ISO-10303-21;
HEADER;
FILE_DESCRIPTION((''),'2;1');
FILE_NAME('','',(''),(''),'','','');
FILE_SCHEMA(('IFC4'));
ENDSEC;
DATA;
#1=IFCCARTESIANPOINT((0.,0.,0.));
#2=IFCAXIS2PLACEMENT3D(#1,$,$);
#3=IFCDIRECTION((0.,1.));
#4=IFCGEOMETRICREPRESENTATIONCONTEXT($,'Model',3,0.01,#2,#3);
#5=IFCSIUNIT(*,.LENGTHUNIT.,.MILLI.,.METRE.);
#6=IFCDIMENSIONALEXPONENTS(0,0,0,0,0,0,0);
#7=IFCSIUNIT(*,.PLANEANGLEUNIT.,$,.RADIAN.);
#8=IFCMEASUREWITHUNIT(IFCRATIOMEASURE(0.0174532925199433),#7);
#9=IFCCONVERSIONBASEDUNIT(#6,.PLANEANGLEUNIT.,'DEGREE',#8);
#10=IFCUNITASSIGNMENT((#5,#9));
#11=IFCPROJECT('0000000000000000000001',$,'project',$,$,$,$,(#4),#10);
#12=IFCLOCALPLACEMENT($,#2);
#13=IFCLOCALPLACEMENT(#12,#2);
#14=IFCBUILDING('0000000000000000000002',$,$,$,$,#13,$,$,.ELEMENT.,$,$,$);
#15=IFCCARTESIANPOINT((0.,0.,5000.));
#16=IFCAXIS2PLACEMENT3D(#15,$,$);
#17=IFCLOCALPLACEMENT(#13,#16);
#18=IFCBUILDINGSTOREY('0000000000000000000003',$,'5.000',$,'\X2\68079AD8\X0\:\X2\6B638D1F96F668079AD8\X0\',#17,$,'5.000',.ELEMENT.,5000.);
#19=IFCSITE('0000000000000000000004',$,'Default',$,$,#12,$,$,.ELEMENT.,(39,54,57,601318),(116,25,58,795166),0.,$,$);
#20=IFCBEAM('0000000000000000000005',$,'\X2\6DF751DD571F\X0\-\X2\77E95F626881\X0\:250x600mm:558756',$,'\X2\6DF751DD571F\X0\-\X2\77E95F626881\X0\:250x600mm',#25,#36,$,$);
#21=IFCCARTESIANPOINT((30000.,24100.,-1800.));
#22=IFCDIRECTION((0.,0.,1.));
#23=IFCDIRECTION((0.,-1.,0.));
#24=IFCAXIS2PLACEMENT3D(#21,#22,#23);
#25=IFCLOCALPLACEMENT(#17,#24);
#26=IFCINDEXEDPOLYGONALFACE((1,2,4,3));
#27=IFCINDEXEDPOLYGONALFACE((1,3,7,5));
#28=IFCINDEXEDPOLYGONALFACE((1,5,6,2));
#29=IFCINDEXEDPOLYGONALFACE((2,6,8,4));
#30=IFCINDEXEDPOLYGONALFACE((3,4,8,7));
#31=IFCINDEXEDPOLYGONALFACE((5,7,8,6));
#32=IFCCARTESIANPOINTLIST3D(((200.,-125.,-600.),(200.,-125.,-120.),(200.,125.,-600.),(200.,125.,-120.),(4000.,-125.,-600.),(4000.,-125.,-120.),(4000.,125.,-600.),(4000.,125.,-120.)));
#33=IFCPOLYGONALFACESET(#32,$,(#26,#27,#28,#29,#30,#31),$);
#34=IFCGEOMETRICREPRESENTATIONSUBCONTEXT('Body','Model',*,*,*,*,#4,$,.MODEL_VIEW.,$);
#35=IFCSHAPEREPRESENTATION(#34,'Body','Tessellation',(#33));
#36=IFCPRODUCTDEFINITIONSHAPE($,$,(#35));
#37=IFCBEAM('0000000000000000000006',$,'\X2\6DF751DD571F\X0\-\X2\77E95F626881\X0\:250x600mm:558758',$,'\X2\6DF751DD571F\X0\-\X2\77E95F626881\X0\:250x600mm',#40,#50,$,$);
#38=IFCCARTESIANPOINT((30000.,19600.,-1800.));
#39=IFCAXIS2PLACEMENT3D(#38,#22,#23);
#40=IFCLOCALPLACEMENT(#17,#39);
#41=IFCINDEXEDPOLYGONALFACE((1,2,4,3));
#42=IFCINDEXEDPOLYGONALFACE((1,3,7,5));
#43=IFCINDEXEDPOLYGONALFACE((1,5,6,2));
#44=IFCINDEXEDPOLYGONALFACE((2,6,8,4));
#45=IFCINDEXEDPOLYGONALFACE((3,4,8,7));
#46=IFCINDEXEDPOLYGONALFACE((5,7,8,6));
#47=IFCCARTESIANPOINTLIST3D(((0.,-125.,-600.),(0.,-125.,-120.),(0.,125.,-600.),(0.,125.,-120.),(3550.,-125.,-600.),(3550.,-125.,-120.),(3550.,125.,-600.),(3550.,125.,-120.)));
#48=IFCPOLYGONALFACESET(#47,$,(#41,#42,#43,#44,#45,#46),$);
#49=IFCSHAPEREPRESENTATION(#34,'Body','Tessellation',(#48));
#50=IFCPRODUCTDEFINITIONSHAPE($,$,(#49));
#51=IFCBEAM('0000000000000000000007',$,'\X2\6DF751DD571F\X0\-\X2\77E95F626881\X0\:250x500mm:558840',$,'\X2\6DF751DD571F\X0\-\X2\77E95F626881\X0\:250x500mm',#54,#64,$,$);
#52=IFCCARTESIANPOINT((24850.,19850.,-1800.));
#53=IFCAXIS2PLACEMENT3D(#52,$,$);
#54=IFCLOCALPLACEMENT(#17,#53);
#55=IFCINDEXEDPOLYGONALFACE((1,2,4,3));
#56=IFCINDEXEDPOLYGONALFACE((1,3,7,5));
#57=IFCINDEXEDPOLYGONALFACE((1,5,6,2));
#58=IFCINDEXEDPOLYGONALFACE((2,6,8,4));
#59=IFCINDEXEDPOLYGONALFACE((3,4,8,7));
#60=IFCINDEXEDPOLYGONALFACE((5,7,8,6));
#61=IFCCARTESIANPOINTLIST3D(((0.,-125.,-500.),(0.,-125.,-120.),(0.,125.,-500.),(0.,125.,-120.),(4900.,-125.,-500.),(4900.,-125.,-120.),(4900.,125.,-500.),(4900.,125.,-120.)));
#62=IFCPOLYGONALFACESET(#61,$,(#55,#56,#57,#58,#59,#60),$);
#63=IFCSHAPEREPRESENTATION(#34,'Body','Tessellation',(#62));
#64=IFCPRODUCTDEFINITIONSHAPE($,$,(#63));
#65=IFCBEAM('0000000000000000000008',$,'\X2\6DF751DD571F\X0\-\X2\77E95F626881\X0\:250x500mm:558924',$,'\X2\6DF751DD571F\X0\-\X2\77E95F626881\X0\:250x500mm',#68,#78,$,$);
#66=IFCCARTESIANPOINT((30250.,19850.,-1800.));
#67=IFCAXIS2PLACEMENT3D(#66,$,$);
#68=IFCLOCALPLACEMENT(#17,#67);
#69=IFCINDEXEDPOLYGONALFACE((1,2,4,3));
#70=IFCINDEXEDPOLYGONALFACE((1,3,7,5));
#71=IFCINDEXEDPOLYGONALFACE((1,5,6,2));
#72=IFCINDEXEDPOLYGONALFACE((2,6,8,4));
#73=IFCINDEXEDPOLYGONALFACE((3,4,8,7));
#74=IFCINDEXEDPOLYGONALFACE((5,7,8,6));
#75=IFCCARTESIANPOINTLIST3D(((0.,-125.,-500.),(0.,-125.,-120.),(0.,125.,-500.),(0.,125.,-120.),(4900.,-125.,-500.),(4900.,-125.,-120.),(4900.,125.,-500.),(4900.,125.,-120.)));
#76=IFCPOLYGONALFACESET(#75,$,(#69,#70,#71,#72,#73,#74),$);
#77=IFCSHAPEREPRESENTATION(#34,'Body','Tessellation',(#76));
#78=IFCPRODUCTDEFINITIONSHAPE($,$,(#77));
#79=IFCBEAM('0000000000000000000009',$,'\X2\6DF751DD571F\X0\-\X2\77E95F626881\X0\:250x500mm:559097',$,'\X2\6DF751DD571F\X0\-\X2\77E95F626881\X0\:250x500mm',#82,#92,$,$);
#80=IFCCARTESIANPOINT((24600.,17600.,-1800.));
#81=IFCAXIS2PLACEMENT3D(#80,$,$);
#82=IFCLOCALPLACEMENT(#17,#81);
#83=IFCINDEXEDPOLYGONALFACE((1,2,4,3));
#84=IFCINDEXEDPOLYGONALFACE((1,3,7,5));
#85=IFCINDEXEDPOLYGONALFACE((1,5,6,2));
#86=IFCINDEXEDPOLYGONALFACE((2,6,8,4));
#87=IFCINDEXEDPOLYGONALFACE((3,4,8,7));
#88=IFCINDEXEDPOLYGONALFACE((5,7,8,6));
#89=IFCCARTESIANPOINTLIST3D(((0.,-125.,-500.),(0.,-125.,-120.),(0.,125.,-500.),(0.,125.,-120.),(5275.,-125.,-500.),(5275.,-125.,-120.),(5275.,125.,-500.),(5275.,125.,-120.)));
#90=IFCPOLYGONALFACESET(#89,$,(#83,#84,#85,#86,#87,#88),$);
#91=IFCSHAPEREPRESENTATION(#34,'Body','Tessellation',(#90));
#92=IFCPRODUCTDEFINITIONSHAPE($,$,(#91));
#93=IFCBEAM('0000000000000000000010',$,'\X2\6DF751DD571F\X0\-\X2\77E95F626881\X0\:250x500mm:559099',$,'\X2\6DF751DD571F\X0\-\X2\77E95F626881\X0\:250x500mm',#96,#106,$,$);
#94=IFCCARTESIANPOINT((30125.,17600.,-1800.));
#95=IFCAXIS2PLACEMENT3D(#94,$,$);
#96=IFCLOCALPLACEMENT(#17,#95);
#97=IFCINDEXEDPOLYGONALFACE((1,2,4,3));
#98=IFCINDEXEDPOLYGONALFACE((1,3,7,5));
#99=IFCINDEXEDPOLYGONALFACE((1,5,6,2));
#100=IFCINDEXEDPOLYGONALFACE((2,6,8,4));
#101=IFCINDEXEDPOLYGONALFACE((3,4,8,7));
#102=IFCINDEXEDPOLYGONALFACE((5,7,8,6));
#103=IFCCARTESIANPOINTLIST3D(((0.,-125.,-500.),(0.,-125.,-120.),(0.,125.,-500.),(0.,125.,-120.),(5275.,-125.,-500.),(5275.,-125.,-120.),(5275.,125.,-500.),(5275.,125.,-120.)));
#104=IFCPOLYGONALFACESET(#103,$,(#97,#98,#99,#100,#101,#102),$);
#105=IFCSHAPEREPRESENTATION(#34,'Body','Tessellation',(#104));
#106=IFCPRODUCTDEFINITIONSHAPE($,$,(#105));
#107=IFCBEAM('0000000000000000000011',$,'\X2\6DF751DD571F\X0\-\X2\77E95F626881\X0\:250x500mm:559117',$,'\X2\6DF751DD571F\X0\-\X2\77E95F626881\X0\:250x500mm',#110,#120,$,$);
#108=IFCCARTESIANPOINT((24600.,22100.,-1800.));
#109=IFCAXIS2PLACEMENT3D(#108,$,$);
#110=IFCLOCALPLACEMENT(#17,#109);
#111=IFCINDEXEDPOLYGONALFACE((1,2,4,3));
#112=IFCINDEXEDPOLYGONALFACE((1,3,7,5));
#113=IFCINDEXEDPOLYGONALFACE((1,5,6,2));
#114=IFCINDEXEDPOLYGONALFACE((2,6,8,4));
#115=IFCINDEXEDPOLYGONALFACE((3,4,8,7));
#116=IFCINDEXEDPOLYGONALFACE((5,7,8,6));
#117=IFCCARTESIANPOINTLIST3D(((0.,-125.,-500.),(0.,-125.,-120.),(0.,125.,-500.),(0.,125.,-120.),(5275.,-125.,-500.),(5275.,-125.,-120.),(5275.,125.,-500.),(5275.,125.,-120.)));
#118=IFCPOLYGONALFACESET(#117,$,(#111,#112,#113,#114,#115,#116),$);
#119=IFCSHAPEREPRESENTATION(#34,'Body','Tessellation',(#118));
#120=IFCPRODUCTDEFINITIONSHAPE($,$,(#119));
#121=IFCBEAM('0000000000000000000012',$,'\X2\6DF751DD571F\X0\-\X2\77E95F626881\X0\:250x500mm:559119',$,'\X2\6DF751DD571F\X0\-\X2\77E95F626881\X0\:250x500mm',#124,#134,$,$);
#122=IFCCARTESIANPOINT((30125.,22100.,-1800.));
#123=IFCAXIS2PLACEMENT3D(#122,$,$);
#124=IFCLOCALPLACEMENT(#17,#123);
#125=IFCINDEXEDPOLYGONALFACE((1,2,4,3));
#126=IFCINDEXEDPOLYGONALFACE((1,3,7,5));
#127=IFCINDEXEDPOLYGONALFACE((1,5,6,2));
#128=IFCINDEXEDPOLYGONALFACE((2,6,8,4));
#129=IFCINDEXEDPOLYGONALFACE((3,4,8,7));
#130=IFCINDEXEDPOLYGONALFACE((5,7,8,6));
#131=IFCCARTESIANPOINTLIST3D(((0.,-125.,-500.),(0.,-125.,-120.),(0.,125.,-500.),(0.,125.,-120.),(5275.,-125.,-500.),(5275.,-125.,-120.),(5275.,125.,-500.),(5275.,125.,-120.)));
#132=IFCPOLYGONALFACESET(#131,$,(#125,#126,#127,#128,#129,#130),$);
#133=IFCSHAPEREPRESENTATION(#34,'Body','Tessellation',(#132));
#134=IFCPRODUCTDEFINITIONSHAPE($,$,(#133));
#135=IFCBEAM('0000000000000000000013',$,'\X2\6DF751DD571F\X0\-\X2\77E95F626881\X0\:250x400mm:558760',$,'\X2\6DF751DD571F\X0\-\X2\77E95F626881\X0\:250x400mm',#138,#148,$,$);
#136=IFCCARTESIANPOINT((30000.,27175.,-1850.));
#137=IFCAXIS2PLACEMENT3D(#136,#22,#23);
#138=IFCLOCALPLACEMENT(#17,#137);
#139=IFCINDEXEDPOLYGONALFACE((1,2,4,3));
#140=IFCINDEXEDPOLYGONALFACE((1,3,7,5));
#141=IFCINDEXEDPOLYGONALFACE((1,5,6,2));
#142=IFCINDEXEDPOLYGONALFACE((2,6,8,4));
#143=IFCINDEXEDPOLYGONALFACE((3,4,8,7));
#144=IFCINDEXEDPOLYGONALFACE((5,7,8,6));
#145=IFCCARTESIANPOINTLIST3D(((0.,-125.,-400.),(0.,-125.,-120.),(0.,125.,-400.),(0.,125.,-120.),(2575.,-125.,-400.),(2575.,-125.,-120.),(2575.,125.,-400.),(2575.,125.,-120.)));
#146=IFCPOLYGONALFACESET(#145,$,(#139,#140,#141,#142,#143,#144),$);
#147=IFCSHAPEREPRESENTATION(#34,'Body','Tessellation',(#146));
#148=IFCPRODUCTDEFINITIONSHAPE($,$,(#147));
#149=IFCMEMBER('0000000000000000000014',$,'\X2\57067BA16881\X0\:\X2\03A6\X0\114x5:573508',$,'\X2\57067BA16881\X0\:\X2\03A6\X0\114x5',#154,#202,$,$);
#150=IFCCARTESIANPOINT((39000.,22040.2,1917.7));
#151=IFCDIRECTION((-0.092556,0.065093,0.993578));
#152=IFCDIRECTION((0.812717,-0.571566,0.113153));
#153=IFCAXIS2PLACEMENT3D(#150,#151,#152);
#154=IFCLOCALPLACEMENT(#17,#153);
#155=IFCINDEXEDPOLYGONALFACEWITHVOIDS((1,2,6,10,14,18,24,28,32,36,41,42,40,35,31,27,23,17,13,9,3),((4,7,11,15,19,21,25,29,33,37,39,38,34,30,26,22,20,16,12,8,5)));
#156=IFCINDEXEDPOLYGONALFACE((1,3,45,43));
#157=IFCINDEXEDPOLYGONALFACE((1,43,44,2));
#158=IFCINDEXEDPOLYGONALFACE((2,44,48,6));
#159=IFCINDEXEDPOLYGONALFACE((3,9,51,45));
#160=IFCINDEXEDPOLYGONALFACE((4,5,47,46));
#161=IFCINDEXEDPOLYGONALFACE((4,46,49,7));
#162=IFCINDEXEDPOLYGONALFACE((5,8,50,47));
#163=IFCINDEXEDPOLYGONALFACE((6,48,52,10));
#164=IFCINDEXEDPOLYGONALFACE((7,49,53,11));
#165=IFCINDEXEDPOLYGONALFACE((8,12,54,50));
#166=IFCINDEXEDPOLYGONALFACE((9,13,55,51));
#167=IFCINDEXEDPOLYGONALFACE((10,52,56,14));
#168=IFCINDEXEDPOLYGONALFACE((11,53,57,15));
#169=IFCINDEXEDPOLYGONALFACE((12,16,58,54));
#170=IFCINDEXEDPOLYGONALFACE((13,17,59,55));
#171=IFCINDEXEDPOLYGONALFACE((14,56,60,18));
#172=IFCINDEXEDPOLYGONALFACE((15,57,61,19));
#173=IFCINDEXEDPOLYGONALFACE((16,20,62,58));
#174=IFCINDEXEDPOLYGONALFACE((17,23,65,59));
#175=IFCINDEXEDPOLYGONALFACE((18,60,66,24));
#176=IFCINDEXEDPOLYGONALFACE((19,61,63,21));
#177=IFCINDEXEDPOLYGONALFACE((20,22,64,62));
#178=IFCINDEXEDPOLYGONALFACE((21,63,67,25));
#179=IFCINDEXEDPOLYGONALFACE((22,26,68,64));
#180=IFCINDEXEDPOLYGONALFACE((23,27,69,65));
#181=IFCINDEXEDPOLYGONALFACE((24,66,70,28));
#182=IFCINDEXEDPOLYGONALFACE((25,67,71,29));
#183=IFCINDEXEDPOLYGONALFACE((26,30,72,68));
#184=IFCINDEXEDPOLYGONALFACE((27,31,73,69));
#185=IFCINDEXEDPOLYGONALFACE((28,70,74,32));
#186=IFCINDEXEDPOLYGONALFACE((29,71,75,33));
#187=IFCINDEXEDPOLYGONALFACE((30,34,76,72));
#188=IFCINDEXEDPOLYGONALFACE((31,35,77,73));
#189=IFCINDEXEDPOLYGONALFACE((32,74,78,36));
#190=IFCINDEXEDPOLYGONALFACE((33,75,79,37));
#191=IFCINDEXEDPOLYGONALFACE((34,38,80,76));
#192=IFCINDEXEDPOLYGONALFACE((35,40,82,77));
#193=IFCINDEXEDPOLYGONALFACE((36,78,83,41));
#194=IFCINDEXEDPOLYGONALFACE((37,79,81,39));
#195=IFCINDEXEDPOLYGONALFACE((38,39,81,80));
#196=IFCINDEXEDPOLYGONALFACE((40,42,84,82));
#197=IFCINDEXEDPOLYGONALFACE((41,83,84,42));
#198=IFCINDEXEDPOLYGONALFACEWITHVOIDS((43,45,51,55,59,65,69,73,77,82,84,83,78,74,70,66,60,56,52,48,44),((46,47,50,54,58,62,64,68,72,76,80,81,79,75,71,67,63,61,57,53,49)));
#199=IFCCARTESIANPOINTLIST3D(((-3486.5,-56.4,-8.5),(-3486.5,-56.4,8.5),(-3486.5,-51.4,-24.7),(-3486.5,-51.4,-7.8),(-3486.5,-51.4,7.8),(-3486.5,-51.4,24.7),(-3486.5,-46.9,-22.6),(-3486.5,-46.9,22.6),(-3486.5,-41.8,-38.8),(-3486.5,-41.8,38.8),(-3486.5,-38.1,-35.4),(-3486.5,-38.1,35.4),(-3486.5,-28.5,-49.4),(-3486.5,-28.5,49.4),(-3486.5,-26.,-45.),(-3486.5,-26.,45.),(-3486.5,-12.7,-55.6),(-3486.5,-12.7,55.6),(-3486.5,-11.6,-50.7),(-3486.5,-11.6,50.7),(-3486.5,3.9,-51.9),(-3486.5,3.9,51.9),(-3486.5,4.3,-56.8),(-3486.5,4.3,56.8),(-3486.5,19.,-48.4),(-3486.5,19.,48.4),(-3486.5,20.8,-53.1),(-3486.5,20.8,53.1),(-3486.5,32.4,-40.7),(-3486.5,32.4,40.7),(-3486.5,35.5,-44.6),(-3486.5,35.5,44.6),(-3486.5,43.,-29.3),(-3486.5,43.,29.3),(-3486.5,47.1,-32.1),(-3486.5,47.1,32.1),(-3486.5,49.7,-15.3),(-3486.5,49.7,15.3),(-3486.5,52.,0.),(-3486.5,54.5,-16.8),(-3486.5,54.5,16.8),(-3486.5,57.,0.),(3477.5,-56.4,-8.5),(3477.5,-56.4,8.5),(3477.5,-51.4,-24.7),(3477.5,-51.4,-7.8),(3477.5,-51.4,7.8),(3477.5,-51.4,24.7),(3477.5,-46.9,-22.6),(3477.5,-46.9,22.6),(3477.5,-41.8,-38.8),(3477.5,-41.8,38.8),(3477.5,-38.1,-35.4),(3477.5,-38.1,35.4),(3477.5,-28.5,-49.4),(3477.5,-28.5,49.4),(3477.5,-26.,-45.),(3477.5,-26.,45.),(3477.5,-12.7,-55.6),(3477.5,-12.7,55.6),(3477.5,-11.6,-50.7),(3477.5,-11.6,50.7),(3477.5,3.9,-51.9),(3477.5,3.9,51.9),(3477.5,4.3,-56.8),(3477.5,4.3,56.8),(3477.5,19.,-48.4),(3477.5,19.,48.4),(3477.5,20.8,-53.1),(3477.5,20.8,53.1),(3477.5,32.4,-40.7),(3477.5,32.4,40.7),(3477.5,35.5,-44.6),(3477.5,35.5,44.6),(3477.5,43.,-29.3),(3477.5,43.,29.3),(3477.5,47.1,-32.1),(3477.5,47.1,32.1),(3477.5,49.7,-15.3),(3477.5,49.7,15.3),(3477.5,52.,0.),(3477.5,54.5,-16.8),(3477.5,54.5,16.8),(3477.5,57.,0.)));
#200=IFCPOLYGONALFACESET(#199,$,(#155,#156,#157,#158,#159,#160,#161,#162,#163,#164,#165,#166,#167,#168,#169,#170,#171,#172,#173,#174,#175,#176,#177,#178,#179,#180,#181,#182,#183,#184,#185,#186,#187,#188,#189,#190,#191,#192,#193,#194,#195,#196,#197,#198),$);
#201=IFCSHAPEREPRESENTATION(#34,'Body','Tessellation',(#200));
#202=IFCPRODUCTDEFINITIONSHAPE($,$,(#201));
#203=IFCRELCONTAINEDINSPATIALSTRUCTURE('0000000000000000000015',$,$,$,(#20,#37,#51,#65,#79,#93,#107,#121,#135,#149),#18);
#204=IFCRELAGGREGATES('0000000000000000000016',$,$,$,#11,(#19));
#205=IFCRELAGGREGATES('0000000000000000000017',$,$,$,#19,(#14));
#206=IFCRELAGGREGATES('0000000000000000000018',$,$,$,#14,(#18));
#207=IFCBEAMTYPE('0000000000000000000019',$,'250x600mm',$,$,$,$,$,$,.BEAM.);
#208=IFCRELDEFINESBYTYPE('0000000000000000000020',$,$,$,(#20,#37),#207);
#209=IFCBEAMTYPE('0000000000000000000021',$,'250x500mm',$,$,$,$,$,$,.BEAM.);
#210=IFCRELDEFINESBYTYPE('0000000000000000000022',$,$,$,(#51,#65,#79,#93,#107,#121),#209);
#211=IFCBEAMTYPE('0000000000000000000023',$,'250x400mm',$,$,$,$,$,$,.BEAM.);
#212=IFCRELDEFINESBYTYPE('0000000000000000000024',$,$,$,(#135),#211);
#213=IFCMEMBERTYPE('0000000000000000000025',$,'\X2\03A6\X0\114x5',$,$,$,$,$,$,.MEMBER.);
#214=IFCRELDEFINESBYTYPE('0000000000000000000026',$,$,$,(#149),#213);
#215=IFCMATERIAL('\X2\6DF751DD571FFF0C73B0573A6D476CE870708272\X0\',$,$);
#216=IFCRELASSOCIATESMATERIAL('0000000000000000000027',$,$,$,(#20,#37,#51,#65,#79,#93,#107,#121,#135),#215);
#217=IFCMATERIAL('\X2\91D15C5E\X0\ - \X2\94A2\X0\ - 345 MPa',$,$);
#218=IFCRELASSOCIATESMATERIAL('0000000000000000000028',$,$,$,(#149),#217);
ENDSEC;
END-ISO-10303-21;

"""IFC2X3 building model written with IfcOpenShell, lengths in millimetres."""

from ifc_helpers import new_model, entity, si_unit, converted_unit, direction, frame, frame_2d, origin, place, context, subcontext, project, spatial, rectangle, hollow_circle, extrude, source, transform, mapped, material, type_object, type_shapes, element, save


model = new_model("IFC2X3")

# Units and contexts
model_context = context("Model", 3, precision=0.01, world=origin(), true_north=direction((0.0, 1.0)))
body_context = subcontext(model_context, "Body", "Model", "MODEL_VIEW")
ifc_project = project(units=[si_unit("LENGTHUNIT", "METRE", prefix="MILLI"), converted_unit("PLANEANGLEUNIT", "DEGREE", entity("IfcRatioMeasure", 0.0174532925199433), si_unit("PLANEANGLEUNIT", "RADIAN"), dimensions=[0, 0, 0, 0, 0, 0, 0])], contexts=[model_context])

# Site, building, storey
site_placement = place(None, origin())
site = spatial("IfcSite", under=ifc_project, at=site_placement, Name="Default", CompositionType="ELEMENT", RefLatitude=(39, 54, 57, 601318), RefLongitude=(116, 25, 58, 795166), RefElevation=0.0)
building_placement = place(site_placement, origin())
building = spatial("IfcBuilding", under=site, at=building_placement, CompositionType="ELEMENT")
storey_placement = place(building_placement, frame((0.0, 0.0, 5000.0)))
storey = spatial("IfcBuildingStorey", under=building, at=storey_placement, Name="5.000", ObjectType="标高:正负零标高", LongName="5.000", CompositionType="ELEMENT", Elevation=5000.0)

# Beams
ifc_material_1 = material(Name="混凝土，现场浇注灰色")
beam_type_1 = type_object("IfcBeamType", Name="250x600mm", PredefinedType="BEAM")
beam_1_placement = place(storey_placement, frame((30000.0, 24100.0, -1800.0), z_axis=(0.0, 0.0, 1.0), x_axis=(0.0, -1.0, 0.0)))
element("IfcBeam", 1, at=beam_1_placement, inside=storey, type_object=beam_type_1, material=ifc_material_1, Name="混凝土-矩形梁:250x600mm:558756", ObjectType="混凝土-矩形梁:250x600mm", context=body_context, shape_type="SweptSolid", body=[
    extrude(rectangle(XDim=480.0, YDim=250.0, at=frame_2d((0.0, 0.0), x_axis=(1.0, 0.0))), frame((200.0, 0.0, -360.0), z_axis=(1.0, 0.0, 0.0), x_axis=(0.0, 0.0, -1.0)), (0.0, 0.0, 1.0), 3800.0),
])
beam_2_placement = place(storey_placement, frame((30000.0, 19600.0, -1800.0), z_axis=(0.0, 0.0, 1.0), x_axis=(0.0, -1.0, 0.0)))
element("IfcBeam", 2, at=beam_2_placement, inside=storey, type_object=beam_type_1, material=ifc_material_1, Name="混凝土-矩形梁:250x600mm:558758", ObjectType="混凝土-矩形梁:250x600mm", context=body_context, shape_type="SweptSolid", body=[
    extrude(rectangle(XDim=480.0, YDim=250.0, at=frame_2d((0.0, 0.0), x_axis=(1.0, 0.0))), frame((0.0, 0.0, -360.0), z_axis=(1.0, 0.0, 0.0), x_axis=(0.0, 0.0, -1.0)), (0.0, 0.0, 1.0), 3550.0),
])
beam_type_2 = type_object("IfcBeamType", Name="250x500mm", PredefinedType="BEAM")
beam_3_placement = place(storey_placement, frame((24850.0, 19850.0, -1800.0)))
element("IfcBeam", 3, at=beam_3_placement, inside=storey, type_object=beam_type_2, material=ifc_material_1, Name="混凝土-矩形梁:250x500mm:558840", ObjectType="混凝土-矩形梁:250x500mm", context=body_context, shape_type="SweptSolid", body=[
    extrude(rectangle(XDim=380.0, YDim=250.0, at=frame_2d((0.0, 0.0), x_axis=(1.0, 0.0))), frame((0.0, 0.0, -310.0), z_axis=(1.0, 0.0, 0.0), x_axis=(0.0, 0.0, -1.0)), (0.0, 0.0, 1.0), 4900.0),
])
beam_4_placement = place(storey_placement, frame((30250.0, 19850.0, -1800.0)))
element("IfcBeam", 4, at=beam_4_placement, inside=storey, type_object=beam_type_2, material=ifc_material_1, Name="混凝土-矩形梁:250x500mm:558924", ObjectType="混凝土-矩形梁:250x500mm", context=body_context, shape_type="SweptSolid", body=[
    extrude(rectangle(XDim=380.0, YDim=250.0, at=frame_2d((0.0, 0.0), x_axis=(1.0, 0.0))), frame((0.0, 0.0, -310.0), z_axis=(1.0, 0.0, 0.0), x_axis=(0.0, 0.0, -1.0)), (0.0, 0.0, 1.0), 4900.0),
])
for number, where, name in (
    (5, (24600.0, 17600.0, -1800.0), "混凝土-矩形梁:250x500mm:559097"),
    (6, (30125.0, 17600.0, -1800.0), "混凝土-矩形梁:250x500mm:559099"),
    (7, (24600.0, 22100.0, -1800.0), "混凝土-矩形梁:250x500mm:559117"),
):
    element("IfcBeam", number, at=place(storey_placement, frame(where)), inside=storey, type_object=beam_type_2, material=ifc_material_1, Name=name, ObjectType="混凝土-矩形梁:250x500mm", context=body_context, shape_type="SweptSolid", body=[
        extrude(rectangle(XDim=380.0, YDim=250.0, at=frame_2d((0.0, 0.0), x_axis=(1.0, 0.0))), frame((0.0, 0.0, -310.0), z_axis=(1.0, 0.0, 0.0), x_axis=(0.0, 0.0, -1.0)), (0.0, 0.0, 1.0), 5275.0),
    ])
beam_5_placement = place(storey_placement, frame((30125.0, 22100.0, -1800.0)))
element("IfcBeam", 8, at=beam_5_placement, inside=storey, type_object=beam_type_2, material=ifc_material_1, Name="混凝土-矩形梁:250x500mm:559119", ObjectType="混凝土-矩形梁:250x500mm", context=body_context, shape_type="SweptSolid", body=[
    extrude(rectangle(XDim=380.0, YDim=250.0, at=frame_2d((0.0, 0.0), x_axis=(1.0, 0.0))), frame((0.0, 0.0, -310.0), z_axis=(1.0, 0.0, 0.0), x_axis=(0.0, 0.0, -1.0)), (0.0, 0.0, 1.0), 5275.0),
])
beam_type_3 = type_object("IfcBeamType", Name="250x400mm", PredefinedType="BEAM")
beam_6_placement = place(storey_placement, frame((30000.0, 27175.0, -1850.0), z_axis=(0.0, 0.0, 1.0), x_axis=(0.0, -1.0, 0.0)))
element("IfcBeam", 9, at=beam_6_placement, inside=storey, type_object=beam_type_3, material=ifc_material_1, Name="混凝土-矩形梁:250x400mm:558760", ObjectType="混凝土-矩形梁:250x400mm", context=body_context, shape_type="SweptSolid", body=[
    extrude(rectangle(XDim=280.0, YDim=250.0, at=frame_2d((0.0, 0.0), x_axis=(1.0, 0.0))), frame((0.0, 0.0, -260.0), z_axis=(1.0, 0.0, 0.0), x_axis=(0.0, 0.0, -1.0)), (0.0, 0.0, 1.0), 2575.0),
])

# Member
ifc_material_2 = material(Name="金属 - 钢 - 345 MPa")
member_type_1 = type_object("IfcMemberType", Name="Φ114x5", PredefinedType="MEMBER")
shared_shape_1 = source(origin(), body_context, "Body", "SweptSolid", [
    extrude(hollow_circle(Radius=57.0, WallThickness=5.0, at=frame_2d((0.0, 0.0), x_axis=(1.0, 0.0))), frame((-3486.5, 0.0, 0.0), z_axis=(1.0, 0.0, 0.0), x_axis=(0.0, 1.0, 0.0)), (0.0, 0.0, 1.0), 6964.0),
])
type_shapes(member_type_1, [shared_shape_1])
for number, where, z_axis, x_axis, name in (
    (10, (39000.0, 22040.2, 1917.7), (-0.092556, 0.065093, 0.993578), (0.812717, -0.571566, 0.113153), "圆管梁:Φ114x5:573508"),
):
    element("IfcMember", number, at=place(storey_placement, frame(where, z_axis=z_axis, x_axis=x_axis)), inside=storey, type_object=member_type_1, material=ifc_material_2, Name=name, ObjectType="圆管梁:Φ114x5", context=body_context, shape_type="MappedRepresentation", body=[
        mapped(shared_shape_1, transform((0.0, 0.0, 0.0), scale=1.0)),
    ])

save(model, "model.ifc")
